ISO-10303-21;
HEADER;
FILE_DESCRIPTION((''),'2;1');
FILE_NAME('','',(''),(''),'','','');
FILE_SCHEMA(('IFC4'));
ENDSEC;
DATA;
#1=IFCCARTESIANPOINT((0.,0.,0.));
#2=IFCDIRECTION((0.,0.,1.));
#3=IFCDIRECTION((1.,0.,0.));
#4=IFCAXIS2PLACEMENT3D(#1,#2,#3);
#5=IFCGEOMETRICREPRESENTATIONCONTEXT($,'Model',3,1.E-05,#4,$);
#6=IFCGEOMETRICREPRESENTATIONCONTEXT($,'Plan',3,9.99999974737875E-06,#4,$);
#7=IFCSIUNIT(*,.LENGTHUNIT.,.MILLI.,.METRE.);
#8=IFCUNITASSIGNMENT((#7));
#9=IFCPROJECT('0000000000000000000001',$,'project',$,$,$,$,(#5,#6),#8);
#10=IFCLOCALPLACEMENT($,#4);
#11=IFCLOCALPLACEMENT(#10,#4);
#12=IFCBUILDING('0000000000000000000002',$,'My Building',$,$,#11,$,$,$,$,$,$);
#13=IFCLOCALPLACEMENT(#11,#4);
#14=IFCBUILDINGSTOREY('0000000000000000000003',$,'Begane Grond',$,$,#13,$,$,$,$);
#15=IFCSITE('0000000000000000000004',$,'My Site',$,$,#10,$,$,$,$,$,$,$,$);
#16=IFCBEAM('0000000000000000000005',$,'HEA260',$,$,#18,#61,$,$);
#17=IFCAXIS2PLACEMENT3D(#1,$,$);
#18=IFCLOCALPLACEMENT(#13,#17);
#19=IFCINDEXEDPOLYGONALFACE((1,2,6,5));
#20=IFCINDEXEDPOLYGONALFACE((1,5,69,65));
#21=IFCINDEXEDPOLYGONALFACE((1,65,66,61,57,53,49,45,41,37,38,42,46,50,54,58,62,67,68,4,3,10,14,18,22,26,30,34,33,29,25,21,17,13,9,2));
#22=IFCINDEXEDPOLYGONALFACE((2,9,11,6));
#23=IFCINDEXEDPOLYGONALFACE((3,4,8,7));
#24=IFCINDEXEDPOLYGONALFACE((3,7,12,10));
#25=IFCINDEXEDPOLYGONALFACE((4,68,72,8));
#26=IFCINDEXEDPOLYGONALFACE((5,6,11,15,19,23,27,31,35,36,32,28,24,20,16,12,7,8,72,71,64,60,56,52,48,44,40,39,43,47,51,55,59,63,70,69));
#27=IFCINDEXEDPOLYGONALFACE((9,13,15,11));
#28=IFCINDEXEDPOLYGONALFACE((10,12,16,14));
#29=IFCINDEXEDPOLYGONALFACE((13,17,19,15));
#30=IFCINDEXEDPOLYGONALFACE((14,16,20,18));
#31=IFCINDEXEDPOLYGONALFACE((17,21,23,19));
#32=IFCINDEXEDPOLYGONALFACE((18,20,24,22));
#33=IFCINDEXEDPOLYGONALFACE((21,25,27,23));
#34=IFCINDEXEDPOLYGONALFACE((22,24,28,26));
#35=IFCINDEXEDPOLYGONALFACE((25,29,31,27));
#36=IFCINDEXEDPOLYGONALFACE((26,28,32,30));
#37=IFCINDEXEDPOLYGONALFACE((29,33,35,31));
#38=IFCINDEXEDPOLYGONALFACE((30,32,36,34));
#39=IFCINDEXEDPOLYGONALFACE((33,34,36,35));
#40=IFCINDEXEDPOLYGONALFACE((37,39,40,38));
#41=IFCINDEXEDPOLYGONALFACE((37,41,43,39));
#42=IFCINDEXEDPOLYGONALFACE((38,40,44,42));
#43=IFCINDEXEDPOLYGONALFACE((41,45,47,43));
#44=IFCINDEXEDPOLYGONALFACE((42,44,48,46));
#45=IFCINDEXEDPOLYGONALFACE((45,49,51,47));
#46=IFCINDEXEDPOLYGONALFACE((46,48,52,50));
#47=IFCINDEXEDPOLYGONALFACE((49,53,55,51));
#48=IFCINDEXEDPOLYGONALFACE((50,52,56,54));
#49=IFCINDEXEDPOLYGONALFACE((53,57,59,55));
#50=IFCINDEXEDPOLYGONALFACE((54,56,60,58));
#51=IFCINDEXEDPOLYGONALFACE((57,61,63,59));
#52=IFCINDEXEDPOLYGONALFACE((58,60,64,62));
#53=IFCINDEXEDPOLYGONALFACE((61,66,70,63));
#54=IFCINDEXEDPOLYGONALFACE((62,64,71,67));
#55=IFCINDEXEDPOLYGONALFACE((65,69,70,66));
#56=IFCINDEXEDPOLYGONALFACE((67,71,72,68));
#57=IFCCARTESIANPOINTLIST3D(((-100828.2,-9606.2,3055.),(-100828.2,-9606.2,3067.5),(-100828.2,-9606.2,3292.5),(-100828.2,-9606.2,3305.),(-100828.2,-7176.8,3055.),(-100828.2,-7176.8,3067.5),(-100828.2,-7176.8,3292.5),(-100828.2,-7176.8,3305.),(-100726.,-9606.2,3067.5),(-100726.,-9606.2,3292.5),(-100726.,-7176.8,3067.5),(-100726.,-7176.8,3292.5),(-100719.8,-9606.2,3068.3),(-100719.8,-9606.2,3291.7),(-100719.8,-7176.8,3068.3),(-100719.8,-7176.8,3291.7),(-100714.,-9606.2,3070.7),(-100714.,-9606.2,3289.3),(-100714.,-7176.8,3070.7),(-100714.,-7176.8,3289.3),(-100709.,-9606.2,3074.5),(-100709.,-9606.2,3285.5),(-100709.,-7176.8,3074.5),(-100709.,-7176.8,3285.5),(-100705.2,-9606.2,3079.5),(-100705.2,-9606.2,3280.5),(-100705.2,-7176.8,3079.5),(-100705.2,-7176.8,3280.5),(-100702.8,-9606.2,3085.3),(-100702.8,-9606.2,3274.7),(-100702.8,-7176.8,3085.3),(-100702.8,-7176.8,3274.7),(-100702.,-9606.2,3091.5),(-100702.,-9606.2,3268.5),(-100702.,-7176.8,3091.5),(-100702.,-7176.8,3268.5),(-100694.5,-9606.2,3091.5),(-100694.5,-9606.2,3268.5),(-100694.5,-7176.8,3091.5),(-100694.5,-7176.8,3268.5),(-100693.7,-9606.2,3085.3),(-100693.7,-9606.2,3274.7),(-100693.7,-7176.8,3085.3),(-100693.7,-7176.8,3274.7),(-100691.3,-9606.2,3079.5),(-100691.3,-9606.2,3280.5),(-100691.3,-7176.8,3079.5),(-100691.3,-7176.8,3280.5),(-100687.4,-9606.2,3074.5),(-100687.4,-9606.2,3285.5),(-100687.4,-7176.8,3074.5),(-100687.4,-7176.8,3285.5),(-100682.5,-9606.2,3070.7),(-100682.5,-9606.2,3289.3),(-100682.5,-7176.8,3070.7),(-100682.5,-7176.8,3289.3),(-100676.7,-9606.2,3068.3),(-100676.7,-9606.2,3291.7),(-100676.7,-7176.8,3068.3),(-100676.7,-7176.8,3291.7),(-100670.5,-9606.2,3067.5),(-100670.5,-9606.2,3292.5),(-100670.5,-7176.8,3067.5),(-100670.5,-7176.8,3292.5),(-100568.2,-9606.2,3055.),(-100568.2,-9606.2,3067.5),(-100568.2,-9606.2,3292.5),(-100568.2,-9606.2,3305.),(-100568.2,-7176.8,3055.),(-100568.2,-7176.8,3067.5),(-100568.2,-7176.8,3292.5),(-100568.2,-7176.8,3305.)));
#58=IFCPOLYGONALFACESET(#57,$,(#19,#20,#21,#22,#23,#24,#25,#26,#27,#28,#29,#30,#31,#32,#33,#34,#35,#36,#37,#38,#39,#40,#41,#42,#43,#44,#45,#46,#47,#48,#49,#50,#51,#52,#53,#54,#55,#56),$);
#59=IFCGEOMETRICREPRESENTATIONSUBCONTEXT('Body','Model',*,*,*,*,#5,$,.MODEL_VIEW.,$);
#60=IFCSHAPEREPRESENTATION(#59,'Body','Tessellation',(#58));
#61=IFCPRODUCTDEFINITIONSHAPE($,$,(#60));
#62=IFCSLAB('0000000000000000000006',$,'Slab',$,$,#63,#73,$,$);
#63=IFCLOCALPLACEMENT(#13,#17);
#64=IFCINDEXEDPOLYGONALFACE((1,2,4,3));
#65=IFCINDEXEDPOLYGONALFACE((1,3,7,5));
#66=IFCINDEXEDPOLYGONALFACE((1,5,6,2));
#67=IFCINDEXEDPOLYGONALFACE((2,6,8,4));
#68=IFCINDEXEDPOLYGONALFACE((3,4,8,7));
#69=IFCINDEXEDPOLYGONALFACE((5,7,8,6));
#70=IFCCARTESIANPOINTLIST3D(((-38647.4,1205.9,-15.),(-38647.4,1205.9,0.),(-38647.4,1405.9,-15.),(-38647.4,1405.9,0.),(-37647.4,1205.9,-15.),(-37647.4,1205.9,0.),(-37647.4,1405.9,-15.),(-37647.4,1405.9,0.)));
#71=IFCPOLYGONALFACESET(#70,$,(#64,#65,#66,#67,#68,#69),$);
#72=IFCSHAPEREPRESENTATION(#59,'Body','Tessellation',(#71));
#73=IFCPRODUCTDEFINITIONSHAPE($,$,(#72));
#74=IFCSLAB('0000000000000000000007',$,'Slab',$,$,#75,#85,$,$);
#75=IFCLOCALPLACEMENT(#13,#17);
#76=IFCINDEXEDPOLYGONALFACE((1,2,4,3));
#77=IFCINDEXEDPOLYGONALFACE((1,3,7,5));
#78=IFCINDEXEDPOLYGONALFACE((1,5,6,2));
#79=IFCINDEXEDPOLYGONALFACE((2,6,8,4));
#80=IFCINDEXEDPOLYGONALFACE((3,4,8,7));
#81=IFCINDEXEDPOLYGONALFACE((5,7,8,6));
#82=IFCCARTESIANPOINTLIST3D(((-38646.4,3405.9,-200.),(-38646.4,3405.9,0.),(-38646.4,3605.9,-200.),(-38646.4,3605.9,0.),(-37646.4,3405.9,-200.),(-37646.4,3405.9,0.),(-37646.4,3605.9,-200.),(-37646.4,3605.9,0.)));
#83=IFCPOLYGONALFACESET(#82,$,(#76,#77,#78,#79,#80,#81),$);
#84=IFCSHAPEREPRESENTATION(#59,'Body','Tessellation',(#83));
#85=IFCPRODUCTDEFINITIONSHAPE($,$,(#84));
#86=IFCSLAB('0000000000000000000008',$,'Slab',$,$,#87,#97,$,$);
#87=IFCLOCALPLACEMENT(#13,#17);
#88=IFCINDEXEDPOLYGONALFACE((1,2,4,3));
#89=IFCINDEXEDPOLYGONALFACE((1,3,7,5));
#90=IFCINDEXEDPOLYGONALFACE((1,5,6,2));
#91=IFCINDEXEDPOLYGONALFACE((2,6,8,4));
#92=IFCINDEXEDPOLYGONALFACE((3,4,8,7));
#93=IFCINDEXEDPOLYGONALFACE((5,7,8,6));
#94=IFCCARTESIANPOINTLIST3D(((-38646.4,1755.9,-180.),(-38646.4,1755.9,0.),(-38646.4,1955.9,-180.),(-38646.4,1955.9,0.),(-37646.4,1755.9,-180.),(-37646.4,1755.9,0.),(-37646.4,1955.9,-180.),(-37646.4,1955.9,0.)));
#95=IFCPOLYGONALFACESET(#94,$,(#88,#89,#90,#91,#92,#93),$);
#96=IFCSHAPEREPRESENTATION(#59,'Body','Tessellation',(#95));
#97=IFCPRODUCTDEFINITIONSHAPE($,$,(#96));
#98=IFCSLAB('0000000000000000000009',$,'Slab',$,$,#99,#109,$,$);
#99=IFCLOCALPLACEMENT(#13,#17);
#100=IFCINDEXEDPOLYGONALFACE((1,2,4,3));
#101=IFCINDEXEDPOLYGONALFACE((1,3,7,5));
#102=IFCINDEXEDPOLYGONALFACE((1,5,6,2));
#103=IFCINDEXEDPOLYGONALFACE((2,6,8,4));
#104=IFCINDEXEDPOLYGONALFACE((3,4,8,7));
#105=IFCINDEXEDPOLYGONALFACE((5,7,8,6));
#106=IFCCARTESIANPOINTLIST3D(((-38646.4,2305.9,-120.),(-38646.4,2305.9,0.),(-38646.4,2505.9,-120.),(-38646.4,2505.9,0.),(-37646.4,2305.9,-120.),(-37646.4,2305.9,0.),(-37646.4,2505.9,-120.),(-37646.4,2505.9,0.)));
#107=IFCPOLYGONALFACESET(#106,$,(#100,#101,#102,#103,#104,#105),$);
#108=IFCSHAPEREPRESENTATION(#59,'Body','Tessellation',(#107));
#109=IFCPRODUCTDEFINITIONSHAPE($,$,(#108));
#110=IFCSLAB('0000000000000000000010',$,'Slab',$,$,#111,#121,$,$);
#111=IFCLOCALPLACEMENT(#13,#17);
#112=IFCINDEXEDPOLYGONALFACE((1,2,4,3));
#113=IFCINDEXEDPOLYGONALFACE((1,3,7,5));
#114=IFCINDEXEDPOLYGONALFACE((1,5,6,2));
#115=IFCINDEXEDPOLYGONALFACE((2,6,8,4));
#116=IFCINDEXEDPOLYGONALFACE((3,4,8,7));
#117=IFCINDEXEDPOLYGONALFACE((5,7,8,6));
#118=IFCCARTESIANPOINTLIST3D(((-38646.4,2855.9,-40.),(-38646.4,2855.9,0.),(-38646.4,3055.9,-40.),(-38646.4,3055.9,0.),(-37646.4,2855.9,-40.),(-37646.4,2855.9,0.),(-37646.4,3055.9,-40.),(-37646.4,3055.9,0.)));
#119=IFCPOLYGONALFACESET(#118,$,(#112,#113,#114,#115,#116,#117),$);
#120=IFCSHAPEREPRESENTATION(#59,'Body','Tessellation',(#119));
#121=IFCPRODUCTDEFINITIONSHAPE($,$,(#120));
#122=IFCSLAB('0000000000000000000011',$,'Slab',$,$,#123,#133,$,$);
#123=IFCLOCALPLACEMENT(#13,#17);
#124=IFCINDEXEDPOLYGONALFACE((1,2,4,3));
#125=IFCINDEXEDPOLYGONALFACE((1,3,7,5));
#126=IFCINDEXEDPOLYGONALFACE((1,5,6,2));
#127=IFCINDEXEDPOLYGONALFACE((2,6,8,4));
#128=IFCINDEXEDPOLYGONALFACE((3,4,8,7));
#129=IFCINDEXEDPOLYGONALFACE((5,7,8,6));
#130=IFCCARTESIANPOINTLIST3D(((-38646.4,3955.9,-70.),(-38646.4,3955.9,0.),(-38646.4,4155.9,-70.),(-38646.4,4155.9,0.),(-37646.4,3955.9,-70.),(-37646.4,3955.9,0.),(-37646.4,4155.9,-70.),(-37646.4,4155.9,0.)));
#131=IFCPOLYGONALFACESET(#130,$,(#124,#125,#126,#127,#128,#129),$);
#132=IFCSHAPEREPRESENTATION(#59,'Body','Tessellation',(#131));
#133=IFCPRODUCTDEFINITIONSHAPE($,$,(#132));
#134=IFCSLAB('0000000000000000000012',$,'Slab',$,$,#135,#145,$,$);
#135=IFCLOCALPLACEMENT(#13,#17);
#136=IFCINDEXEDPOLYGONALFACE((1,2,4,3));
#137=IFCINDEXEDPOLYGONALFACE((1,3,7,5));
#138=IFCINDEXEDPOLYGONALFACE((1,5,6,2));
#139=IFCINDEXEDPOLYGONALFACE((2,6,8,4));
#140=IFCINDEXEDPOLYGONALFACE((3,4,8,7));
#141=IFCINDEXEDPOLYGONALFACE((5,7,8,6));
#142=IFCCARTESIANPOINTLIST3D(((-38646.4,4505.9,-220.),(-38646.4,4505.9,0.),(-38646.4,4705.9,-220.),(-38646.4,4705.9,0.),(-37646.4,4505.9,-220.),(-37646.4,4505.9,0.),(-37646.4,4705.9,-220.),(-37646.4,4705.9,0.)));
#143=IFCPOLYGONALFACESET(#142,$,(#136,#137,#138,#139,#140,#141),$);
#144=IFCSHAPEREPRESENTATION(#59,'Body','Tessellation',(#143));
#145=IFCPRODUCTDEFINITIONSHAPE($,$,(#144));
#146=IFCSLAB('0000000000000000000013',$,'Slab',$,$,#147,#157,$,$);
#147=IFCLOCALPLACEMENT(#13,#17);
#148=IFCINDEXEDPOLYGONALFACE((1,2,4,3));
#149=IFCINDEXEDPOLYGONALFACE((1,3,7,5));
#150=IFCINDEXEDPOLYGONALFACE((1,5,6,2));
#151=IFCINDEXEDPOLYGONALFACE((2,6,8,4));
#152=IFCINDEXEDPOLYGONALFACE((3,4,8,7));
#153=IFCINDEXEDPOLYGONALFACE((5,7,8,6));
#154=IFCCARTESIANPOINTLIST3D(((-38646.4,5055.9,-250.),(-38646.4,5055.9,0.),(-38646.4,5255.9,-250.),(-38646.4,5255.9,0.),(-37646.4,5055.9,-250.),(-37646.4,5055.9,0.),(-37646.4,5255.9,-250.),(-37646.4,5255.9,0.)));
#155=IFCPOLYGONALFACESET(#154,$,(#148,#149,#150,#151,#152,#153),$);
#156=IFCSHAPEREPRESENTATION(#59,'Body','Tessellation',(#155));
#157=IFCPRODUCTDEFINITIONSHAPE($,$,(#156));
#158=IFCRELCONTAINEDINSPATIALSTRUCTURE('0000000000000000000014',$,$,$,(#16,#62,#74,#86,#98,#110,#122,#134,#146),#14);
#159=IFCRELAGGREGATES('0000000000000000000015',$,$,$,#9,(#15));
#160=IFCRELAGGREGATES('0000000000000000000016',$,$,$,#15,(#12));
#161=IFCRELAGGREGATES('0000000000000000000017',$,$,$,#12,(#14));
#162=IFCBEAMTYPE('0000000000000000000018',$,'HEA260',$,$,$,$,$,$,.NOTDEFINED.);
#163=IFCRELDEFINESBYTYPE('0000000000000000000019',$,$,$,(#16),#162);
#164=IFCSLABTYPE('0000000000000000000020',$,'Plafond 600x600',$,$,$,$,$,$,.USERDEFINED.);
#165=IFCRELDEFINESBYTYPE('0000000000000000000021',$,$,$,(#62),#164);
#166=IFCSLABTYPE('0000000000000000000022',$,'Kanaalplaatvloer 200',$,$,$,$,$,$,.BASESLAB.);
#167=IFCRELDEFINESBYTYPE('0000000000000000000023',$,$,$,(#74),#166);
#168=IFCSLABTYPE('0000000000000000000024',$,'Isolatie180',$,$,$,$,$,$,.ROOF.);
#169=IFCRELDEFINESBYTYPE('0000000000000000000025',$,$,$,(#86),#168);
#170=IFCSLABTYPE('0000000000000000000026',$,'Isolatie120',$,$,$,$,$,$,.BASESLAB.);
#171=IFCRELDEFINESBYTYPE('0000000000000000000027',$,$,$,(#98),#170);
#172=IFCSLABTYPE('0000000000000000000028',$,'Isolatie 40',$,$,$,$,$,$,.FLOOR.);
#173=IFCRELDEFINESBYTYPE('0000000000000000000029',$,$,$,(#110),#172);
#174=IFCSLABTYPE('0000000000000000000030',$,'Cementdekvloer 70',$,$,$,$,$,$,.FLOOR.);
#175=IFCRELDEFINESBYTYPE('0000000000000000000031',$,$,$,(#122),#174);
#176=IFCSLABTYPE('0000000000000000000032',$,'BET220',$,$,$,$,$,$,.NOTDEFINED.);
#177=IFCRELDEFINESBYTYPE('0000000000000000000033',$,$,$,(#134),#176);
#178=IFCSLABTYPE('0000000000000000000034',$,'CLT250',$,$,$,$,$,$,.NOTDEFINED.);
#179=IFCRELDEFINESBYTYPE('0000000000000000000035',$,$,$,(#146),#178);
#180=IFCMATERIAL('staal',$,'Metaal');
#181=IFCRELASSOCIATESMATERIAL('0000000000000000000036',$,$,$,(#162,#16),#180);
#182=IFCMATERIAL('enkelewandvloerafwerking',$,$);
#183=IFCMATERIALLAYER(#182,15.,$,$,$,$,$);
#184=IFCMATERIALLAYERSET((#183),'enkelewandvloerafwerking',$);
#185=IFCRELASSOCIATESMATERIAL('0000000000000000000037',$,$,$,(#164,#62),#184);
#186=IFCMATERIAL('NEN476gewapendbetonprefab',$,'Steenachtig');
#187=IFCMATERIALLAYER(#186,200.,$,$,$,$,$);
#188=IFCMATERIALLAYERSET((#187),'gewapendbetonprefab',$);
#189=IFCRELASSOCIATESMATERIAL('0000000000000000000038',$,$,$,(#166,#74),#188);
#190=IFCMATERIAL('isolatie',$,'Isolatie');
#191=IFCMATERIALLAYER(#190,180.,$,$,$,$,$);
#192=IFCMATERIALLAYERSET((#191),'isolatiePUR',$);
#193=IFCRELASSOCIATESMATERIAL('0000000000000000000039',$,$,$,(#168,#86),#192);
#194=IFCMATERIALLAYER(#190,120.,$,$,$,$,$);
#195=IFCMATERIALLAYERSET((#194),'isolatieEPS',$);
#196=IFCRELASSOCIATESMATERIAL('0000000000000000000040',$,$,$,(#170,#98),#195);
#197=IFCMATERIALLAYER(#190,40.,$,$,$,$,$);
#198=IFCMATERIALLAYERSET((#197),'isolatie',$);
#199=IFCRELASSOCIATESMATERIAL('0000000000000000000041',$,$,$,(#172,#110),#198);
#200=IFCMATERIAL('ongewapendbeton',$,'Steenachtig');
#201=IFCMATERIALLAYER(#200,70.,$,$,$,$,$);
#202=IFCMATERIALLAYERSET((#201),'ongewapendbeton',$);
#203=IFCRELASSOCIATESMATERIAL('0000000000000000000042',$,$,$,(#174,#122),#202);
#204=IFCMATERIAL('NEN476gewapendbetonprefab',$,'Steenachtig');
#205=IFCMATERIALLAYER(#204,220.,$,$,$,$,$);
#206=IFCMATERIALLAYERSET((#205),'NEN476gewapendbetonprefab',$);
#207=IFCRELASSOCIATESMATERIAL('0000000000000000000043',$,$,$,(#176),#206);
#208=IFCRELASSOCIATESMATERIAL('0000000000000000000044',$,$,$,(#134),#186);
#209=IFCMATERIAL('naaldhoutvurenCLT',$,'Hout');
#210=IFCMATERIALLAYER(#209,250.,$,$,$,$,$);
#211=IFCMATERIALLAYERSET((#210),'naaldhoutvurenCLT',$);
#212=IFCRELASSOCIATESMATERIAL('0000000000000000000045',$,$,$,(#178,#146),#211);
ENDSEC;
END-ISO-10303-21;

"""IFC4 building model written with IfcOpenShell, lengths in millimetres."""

from ifc_helpers import new_model, si_unit, frame, origin_with_axes, place, context, subcontext, project, spatial, line, indexed_curve, i_section, outline, extrude, material, layer, layer_set, layer_usage, material_profile, profile_set, profile_usage, type_object, element, save


model = new_model("IFC4")

# Units and contexts
model_context = context("Model", 3, precision=1e-05, world=origin_with_axes())
plan_context = context("Plan", 3, precision=9.99999974737875e-06, world=origin_with_axes())
body_context = subcontext(model_context, "Body", "Model", "MODEL_VIEW")
ifc_project = project(units=[si_unit("LENGTHUNIT", "METRE", prefix="MILLI")], contexts=[model_context, plan_context])

# Site, building, storey
site_placement = place(None, frame((0.0, 0.0, 0.0), z_axis=(0.0, 0.0, 1.0), x_axis=(1.0, 0.0, 0.0)))
site = spatial("IfcSite", under=ifc_project, at=site_placement, Name="My Site")
building_placement = place(site_placement, origin_with_axes())
building = spatial("IfcBuilding", under=site, at=building_placement, Name="My Building")
storey_placement = place(building_placement, origin_with_axes())
storey = spatial("IfcBuildingStorey", under=building, at=storey_placement, Name="Begane Grond")

# Beam
ifc_material_1 = material(Name="staal", Category="Metaal")
ifc_material_profile = material_profile(ifc_material_1, i_section(OverallWidth=260.0, OverallDepth=250.0, WebThickness=7.5, FlangeThickness=12.5, FilletRadius=24.0))
ifc_profile_set = profile_set([ifc_material_profile], Name="HEA260")
ifc_profile_usage = profile_usage(ifc_profile_set, cardinal=5)
beam_type = type_object("IfcBeamType", Name="HEA260", PredefinedType="NOTDEFINED", material=ifc_profile_set)
beam_placement = place(storey_placement, frame((-100698.2, -9606.2, 3180.0), z_axis=(0.0, 1.0, 0.0), x_axis=(-1.0, 0.0, 0.0)))
element("IfcBeam", 1, at=beam_placement, inside=storey, type_object=beam_type, material=ifc_profile_usage, Name="HEA260", context=body_context, shape_type="SweptSolid", body=[
    extrude(i_section(OverallWidth=260.0, OverallDepth=250.0, WebThickness=7.5, FlangeThickness=12.5, FilletRadius=24.0), origin_with_axes(), (0.0, 0.0, 1.0), 2429.4),
])

# Slabs
ifc_material_2 = material(Name="enkelewandvloerafwerking")
ifc_layer_1 = layer(ifc_material_2, 15.0)
ifc_layer_set_1 = layer_set([ifc_layer_1], Name="enkelewandvloerafwerking")
ifc_layer_usage_1 = layer_usage(ifc_layer_set_1, "AXIS3", "POSITIVE", 0.0)
slab_type_1 = type_object("IfcSlabType", Name="Plafond 600x600", PredefinedType="USERDEFINED", material=ifc_layer_set_1)
slab_1_placement = place(storey_placement, frame((-38647.4, 1205.9, -15.0), z_axis=(0.0, 0.0, 1.0), x_axis=(1.0, 0.0, 0.0)))
element("IfcSlab", 2, at=slab_1_placement, inside=storey, type_object=slab_type_1, material=ifc_layer_usage_1, Name="Slab", context=body_context, shape_type="SweptSolid", body=[
    extrude(outline(indexed_curve([(1000.0, 200.0), (1000.0, 0.0), (0.0, 0.0), (0.0, 200.0)], segments=[line(4, 1), line(1, 2), line(2, 3), line(3, 4)], self_intersect=False)), None, (0.0, 0.0, 1.0), 15.0),
])
ifc_material_3 = material(Name="NEN476gewapendbetonprefab", Category="Steenachtig")
ifc_layer_2 = layer(ifc_material_3, 200.0)
ifc_layer_set_2 = layer_set([ifc_layer_2], Name="gewapendbetonprefab")
ifc_layer_usage_2 = layer_usage(ifc_layer_set_2, "AXIS3", "POSITIVE", 0.0)
slab_type_2 = type_object("IfcSlabType", Name="Kanaalplaatvloer 200", PredefinedType="BASESLAB", material=ifc_layer_set_2)
slab_2_placement = place(storey_placement, frame((-38646.4, 3405.9, -200.0), z_axis=(0.0, 0.0, 1.0), x_axis=(1.0, 0.0, 0.0)))
element("IfcSlab", 3, at=slab_2_placement, inside=storey, type_object=slab_type_2, material=ifc_layer_usage_2, Name="Slab", context=body_context, shape_type="SweptSolid", body=[
    extrude(outline(indexed_curve([(1000.0, 200.0), (1000.0, 0.0), (0.0, 0.0), (0.0, 200.0)], segments=[line(4, 1), line(1, 2), line(2, 3), line(3, 4)], self_intersect=False)), None, (0.0, 0.0, 1.0), 200.0),
])
ifc_material_4 = material(Name="isolatie", Category="Isolatie")
ifc_layer_3 = layer(ifc_material_4, 180.0)
ifc_layer_set_3 = layer_set([ifc_layer_3], Name="isolatiePUR")
ifc_layer_usage_3 = layer_usage(ifc_layer_set_3, "AXIS3", "POSITIVE", 0.0)
slab_type_3 = type_object("IfcSlabType", Name="Isolatie180", PredefinedType="ROOF", material=ifc_layer_set_3)
slab_3_placement = place(storey_placement, frame((-38646.4, 1755.9, -180.0), z_axis=(0.0, 0.0, 1.0), x_axis=(1.0, 0.0, 0.0)))
element("IfcSlab", 4, at=slab_3_placement, inside=storey, type_object=slab_type_3, material=ifc_layer_usage_3, Name="Slab", context=body_context, shape_type="SweptSolid", body=[
    extrude(outline(indexed_curve([(1000.0, 200.0), (1000.0, 0.0), (0.0, 0.0), (0.0, 200.0)], segments=[line(4, 1), line(1, 2), line(2, 3), line(3, 4)], self_intersect=False)), None, (0.0, 0.0, 1.0), 180.0),
])
ifc_layer_4 = layer(ifc_material_4, 120.0)
ifc_layer_set_4 = layer_set([ifc_layer_4], Name="isolatieEPS")
ifc_layer_usage_4 = layer_usage(ifc_layer_set_4, "AXIS3", "POSITIVE", 0.0)
slab_type_4 = type_object("IfcSlabType", Name="Isolatie120", PredefinedType="BASESLAB", material=ifc_layer_set_4)
slab_4_placement = place(storey_placement, frame((-38646.4, 2305.9, -120.0), z_axis=(0.0, 0.0, 1.0), x_axis=(1.0, 0.0, 0.0)))
element("IfcSlab", 5, at=slab_4_placement, inside=storey, type_object=slab_type_4, material=ifc_layer_usage_4, Name="Slab", context=body_context, shape_type="SweptSolid", body=[
    extrude(outline(indexed_curve([(1000.0, 200.0), (1000.0, 0.0), (0.0, 0.0), (0.0, 200.0)], segments=[line(3, 2), line(2, 1), line(1, 4), line(4, 3)], self_intersect=False)), None, (0.0, 0.0, 1.0), 120.0),
])
ifc_layer_5 = layer(ifc_material_4, 40.0)
ifc_layer_set_5 = layer_set([ifc_layer_5], Name="isolatie")
ifc_layer_usage_5 = layer_usage(ifc_layer_set_5, "AXIS3", "POSITIVE", 0.0)
slab_type_5 = type_object("IfcSlabType", Name="Isolatie 40", PredefinedType="FLOOR", material=ifc_layer_set_5)
slab_5_placement = place(storey_placement, frame((-38646.4, 2855.9, -40.0), z_axis=(0.0, 0.0, 1.0), x_axis=(1.0, 0.0, 0.0)))
element("IfcSlab", 6, at=slab_5_placement, inside=storey, type_object=slab_type_5, material=ifc_layer_usage_5, Name="Slab", context=body_context, shape_type="SweptSolid", body=[
    extrude(outline(indexed_curve([(1000.0, 200.0), (1000.0, 0.0), (0.0, 0.0), (0.0, 200.0)], segments=[line(3, 2), line(2, 1), line(1, 4), line(4, 3)], self_intersect=False)), None, (0.0, 0.0, 1.0), 40.0),
])
ifc_material_5 = material(Name="ongewapendbeton", Category="Steenachtig")
ifc_layer_6 = layer(ifc_material_5, 70.0)
ifc_layer_set_6 = layer_set([ifc_layer_6], Name="ongewapendbeton")
ifc_layer_usage_6 = layer_usage(ifc_layer_set_6, "AXIS3", "POSITIVE", 0.0)
slab_type_6 = type_object("IfcSlabType", Name="Cementdekvloer 70", PredefinedType="FLOOR", material=ifc_layer_set_6)
slab_6_placement = place(storey_placement, frame((-38646.4, 3955.9, -70.0), z_axis=(0.0, 0.0, 1.0), x_axis=(1.0, 0.0, 0.0)))
element("IfcSlab", 7, at=slab_6_placement, inside=storey, type_object=slab_type_6, material=ifc_layer_usage_6, Name="Slab", context=body_context, shape_type="SweptSolid", body=[
    extrude(outline(indexed_curve([(1000.0, 200.0), (1000.0, 0.0), (0.0, 0.0), (0.0, 200.0)], segments=[line(4, 1), line(1, 2), line(2, 3), line(3, 4)], self_intersect=False)), None, (0.0, 0.0, 1.0), 70.0),
])
ifc_material_6 = material(Name="NEN476gewapendbetonprefab", Category="Steenachtig")
ifc_layer_7 = layer(ifc_material_6, 220.0)
ifc_layer_set_7 = layer_set([ifc_layer_7], Name="NEN476gewapendbetonprefab")
slab_type_7 = type_object("IfcSlabType", Name="BET220", PredefinedType="NOTDEFINED", material=ifc_layer_set_7)
slab_7_placement = place(storey_placement, frame((-38646.4, 4505.9, -220.0), z_axis=(0.0, 0.0, 1.0), x_axis=(1.0, 0.0, 0.0)))
element("IfcSlab", 8, at=slab_7_placement, inside=storey, type_object=slab_type_7, material=ifc_material_3, Name="Slab", context=body_context, shape_type="SweptSolid", body=[
    extrude(outline(indexed_curve([(1000.0, 200.0), (1000.0, 0.0), (0.0, 0.0), (0.0, 200.0)], segments=[line(4, 1), line(1, 2), line(2, 3), line(3, 4)], self_intersect=False)), None, (0.0, 0.0, 1.0), 220.0),
])
ifc_material_7 = material(Name="naaldhoutvurenCLT", Category="Hout")
ifc_layer_8 = layer(ifc_material_7, 250.0)
ifc_layer_set_8 = layer_set([ifc_layer_8], Name="naaldhoutvurenCLT")
ifc_layer_usage_7 = layer_usage(ifc_layer_set_8, "AXIS3", "POSITIVE", 0.0)
slab_type_8 = type_object("IfcSlabType", Name="CLT250", PredefinedType="NOTDEFINED", material=ifc_layer_set_8)
slab_8_placement = place(storey_placement, frame((-38646.4, 5055.9, -250.0), z_axis=(0.0, 0.0, 1.0), x_axis=(1.0, 0.0, 0.0)))
element("IfcSlab", 9, at=slab_8_placement, inside=storey, type_object=slab_type_8, material=ifc_layer_usage_7, Name="Slab", context=body_context, shape_type="SweptSolid", body=[
    extrude(outline(indexed_curve([(1000.0, 200.0), (1000.0, 0.0), (0.0, 0.0), (0.0, 200.0)], segments=[line(3, 2), line(2, 1), line(1, 4), line(4, 3)], self_intersect=False)), None, (0.0, 0.0, 1.0), 250.0),
])

save(model, "model.ifc")
